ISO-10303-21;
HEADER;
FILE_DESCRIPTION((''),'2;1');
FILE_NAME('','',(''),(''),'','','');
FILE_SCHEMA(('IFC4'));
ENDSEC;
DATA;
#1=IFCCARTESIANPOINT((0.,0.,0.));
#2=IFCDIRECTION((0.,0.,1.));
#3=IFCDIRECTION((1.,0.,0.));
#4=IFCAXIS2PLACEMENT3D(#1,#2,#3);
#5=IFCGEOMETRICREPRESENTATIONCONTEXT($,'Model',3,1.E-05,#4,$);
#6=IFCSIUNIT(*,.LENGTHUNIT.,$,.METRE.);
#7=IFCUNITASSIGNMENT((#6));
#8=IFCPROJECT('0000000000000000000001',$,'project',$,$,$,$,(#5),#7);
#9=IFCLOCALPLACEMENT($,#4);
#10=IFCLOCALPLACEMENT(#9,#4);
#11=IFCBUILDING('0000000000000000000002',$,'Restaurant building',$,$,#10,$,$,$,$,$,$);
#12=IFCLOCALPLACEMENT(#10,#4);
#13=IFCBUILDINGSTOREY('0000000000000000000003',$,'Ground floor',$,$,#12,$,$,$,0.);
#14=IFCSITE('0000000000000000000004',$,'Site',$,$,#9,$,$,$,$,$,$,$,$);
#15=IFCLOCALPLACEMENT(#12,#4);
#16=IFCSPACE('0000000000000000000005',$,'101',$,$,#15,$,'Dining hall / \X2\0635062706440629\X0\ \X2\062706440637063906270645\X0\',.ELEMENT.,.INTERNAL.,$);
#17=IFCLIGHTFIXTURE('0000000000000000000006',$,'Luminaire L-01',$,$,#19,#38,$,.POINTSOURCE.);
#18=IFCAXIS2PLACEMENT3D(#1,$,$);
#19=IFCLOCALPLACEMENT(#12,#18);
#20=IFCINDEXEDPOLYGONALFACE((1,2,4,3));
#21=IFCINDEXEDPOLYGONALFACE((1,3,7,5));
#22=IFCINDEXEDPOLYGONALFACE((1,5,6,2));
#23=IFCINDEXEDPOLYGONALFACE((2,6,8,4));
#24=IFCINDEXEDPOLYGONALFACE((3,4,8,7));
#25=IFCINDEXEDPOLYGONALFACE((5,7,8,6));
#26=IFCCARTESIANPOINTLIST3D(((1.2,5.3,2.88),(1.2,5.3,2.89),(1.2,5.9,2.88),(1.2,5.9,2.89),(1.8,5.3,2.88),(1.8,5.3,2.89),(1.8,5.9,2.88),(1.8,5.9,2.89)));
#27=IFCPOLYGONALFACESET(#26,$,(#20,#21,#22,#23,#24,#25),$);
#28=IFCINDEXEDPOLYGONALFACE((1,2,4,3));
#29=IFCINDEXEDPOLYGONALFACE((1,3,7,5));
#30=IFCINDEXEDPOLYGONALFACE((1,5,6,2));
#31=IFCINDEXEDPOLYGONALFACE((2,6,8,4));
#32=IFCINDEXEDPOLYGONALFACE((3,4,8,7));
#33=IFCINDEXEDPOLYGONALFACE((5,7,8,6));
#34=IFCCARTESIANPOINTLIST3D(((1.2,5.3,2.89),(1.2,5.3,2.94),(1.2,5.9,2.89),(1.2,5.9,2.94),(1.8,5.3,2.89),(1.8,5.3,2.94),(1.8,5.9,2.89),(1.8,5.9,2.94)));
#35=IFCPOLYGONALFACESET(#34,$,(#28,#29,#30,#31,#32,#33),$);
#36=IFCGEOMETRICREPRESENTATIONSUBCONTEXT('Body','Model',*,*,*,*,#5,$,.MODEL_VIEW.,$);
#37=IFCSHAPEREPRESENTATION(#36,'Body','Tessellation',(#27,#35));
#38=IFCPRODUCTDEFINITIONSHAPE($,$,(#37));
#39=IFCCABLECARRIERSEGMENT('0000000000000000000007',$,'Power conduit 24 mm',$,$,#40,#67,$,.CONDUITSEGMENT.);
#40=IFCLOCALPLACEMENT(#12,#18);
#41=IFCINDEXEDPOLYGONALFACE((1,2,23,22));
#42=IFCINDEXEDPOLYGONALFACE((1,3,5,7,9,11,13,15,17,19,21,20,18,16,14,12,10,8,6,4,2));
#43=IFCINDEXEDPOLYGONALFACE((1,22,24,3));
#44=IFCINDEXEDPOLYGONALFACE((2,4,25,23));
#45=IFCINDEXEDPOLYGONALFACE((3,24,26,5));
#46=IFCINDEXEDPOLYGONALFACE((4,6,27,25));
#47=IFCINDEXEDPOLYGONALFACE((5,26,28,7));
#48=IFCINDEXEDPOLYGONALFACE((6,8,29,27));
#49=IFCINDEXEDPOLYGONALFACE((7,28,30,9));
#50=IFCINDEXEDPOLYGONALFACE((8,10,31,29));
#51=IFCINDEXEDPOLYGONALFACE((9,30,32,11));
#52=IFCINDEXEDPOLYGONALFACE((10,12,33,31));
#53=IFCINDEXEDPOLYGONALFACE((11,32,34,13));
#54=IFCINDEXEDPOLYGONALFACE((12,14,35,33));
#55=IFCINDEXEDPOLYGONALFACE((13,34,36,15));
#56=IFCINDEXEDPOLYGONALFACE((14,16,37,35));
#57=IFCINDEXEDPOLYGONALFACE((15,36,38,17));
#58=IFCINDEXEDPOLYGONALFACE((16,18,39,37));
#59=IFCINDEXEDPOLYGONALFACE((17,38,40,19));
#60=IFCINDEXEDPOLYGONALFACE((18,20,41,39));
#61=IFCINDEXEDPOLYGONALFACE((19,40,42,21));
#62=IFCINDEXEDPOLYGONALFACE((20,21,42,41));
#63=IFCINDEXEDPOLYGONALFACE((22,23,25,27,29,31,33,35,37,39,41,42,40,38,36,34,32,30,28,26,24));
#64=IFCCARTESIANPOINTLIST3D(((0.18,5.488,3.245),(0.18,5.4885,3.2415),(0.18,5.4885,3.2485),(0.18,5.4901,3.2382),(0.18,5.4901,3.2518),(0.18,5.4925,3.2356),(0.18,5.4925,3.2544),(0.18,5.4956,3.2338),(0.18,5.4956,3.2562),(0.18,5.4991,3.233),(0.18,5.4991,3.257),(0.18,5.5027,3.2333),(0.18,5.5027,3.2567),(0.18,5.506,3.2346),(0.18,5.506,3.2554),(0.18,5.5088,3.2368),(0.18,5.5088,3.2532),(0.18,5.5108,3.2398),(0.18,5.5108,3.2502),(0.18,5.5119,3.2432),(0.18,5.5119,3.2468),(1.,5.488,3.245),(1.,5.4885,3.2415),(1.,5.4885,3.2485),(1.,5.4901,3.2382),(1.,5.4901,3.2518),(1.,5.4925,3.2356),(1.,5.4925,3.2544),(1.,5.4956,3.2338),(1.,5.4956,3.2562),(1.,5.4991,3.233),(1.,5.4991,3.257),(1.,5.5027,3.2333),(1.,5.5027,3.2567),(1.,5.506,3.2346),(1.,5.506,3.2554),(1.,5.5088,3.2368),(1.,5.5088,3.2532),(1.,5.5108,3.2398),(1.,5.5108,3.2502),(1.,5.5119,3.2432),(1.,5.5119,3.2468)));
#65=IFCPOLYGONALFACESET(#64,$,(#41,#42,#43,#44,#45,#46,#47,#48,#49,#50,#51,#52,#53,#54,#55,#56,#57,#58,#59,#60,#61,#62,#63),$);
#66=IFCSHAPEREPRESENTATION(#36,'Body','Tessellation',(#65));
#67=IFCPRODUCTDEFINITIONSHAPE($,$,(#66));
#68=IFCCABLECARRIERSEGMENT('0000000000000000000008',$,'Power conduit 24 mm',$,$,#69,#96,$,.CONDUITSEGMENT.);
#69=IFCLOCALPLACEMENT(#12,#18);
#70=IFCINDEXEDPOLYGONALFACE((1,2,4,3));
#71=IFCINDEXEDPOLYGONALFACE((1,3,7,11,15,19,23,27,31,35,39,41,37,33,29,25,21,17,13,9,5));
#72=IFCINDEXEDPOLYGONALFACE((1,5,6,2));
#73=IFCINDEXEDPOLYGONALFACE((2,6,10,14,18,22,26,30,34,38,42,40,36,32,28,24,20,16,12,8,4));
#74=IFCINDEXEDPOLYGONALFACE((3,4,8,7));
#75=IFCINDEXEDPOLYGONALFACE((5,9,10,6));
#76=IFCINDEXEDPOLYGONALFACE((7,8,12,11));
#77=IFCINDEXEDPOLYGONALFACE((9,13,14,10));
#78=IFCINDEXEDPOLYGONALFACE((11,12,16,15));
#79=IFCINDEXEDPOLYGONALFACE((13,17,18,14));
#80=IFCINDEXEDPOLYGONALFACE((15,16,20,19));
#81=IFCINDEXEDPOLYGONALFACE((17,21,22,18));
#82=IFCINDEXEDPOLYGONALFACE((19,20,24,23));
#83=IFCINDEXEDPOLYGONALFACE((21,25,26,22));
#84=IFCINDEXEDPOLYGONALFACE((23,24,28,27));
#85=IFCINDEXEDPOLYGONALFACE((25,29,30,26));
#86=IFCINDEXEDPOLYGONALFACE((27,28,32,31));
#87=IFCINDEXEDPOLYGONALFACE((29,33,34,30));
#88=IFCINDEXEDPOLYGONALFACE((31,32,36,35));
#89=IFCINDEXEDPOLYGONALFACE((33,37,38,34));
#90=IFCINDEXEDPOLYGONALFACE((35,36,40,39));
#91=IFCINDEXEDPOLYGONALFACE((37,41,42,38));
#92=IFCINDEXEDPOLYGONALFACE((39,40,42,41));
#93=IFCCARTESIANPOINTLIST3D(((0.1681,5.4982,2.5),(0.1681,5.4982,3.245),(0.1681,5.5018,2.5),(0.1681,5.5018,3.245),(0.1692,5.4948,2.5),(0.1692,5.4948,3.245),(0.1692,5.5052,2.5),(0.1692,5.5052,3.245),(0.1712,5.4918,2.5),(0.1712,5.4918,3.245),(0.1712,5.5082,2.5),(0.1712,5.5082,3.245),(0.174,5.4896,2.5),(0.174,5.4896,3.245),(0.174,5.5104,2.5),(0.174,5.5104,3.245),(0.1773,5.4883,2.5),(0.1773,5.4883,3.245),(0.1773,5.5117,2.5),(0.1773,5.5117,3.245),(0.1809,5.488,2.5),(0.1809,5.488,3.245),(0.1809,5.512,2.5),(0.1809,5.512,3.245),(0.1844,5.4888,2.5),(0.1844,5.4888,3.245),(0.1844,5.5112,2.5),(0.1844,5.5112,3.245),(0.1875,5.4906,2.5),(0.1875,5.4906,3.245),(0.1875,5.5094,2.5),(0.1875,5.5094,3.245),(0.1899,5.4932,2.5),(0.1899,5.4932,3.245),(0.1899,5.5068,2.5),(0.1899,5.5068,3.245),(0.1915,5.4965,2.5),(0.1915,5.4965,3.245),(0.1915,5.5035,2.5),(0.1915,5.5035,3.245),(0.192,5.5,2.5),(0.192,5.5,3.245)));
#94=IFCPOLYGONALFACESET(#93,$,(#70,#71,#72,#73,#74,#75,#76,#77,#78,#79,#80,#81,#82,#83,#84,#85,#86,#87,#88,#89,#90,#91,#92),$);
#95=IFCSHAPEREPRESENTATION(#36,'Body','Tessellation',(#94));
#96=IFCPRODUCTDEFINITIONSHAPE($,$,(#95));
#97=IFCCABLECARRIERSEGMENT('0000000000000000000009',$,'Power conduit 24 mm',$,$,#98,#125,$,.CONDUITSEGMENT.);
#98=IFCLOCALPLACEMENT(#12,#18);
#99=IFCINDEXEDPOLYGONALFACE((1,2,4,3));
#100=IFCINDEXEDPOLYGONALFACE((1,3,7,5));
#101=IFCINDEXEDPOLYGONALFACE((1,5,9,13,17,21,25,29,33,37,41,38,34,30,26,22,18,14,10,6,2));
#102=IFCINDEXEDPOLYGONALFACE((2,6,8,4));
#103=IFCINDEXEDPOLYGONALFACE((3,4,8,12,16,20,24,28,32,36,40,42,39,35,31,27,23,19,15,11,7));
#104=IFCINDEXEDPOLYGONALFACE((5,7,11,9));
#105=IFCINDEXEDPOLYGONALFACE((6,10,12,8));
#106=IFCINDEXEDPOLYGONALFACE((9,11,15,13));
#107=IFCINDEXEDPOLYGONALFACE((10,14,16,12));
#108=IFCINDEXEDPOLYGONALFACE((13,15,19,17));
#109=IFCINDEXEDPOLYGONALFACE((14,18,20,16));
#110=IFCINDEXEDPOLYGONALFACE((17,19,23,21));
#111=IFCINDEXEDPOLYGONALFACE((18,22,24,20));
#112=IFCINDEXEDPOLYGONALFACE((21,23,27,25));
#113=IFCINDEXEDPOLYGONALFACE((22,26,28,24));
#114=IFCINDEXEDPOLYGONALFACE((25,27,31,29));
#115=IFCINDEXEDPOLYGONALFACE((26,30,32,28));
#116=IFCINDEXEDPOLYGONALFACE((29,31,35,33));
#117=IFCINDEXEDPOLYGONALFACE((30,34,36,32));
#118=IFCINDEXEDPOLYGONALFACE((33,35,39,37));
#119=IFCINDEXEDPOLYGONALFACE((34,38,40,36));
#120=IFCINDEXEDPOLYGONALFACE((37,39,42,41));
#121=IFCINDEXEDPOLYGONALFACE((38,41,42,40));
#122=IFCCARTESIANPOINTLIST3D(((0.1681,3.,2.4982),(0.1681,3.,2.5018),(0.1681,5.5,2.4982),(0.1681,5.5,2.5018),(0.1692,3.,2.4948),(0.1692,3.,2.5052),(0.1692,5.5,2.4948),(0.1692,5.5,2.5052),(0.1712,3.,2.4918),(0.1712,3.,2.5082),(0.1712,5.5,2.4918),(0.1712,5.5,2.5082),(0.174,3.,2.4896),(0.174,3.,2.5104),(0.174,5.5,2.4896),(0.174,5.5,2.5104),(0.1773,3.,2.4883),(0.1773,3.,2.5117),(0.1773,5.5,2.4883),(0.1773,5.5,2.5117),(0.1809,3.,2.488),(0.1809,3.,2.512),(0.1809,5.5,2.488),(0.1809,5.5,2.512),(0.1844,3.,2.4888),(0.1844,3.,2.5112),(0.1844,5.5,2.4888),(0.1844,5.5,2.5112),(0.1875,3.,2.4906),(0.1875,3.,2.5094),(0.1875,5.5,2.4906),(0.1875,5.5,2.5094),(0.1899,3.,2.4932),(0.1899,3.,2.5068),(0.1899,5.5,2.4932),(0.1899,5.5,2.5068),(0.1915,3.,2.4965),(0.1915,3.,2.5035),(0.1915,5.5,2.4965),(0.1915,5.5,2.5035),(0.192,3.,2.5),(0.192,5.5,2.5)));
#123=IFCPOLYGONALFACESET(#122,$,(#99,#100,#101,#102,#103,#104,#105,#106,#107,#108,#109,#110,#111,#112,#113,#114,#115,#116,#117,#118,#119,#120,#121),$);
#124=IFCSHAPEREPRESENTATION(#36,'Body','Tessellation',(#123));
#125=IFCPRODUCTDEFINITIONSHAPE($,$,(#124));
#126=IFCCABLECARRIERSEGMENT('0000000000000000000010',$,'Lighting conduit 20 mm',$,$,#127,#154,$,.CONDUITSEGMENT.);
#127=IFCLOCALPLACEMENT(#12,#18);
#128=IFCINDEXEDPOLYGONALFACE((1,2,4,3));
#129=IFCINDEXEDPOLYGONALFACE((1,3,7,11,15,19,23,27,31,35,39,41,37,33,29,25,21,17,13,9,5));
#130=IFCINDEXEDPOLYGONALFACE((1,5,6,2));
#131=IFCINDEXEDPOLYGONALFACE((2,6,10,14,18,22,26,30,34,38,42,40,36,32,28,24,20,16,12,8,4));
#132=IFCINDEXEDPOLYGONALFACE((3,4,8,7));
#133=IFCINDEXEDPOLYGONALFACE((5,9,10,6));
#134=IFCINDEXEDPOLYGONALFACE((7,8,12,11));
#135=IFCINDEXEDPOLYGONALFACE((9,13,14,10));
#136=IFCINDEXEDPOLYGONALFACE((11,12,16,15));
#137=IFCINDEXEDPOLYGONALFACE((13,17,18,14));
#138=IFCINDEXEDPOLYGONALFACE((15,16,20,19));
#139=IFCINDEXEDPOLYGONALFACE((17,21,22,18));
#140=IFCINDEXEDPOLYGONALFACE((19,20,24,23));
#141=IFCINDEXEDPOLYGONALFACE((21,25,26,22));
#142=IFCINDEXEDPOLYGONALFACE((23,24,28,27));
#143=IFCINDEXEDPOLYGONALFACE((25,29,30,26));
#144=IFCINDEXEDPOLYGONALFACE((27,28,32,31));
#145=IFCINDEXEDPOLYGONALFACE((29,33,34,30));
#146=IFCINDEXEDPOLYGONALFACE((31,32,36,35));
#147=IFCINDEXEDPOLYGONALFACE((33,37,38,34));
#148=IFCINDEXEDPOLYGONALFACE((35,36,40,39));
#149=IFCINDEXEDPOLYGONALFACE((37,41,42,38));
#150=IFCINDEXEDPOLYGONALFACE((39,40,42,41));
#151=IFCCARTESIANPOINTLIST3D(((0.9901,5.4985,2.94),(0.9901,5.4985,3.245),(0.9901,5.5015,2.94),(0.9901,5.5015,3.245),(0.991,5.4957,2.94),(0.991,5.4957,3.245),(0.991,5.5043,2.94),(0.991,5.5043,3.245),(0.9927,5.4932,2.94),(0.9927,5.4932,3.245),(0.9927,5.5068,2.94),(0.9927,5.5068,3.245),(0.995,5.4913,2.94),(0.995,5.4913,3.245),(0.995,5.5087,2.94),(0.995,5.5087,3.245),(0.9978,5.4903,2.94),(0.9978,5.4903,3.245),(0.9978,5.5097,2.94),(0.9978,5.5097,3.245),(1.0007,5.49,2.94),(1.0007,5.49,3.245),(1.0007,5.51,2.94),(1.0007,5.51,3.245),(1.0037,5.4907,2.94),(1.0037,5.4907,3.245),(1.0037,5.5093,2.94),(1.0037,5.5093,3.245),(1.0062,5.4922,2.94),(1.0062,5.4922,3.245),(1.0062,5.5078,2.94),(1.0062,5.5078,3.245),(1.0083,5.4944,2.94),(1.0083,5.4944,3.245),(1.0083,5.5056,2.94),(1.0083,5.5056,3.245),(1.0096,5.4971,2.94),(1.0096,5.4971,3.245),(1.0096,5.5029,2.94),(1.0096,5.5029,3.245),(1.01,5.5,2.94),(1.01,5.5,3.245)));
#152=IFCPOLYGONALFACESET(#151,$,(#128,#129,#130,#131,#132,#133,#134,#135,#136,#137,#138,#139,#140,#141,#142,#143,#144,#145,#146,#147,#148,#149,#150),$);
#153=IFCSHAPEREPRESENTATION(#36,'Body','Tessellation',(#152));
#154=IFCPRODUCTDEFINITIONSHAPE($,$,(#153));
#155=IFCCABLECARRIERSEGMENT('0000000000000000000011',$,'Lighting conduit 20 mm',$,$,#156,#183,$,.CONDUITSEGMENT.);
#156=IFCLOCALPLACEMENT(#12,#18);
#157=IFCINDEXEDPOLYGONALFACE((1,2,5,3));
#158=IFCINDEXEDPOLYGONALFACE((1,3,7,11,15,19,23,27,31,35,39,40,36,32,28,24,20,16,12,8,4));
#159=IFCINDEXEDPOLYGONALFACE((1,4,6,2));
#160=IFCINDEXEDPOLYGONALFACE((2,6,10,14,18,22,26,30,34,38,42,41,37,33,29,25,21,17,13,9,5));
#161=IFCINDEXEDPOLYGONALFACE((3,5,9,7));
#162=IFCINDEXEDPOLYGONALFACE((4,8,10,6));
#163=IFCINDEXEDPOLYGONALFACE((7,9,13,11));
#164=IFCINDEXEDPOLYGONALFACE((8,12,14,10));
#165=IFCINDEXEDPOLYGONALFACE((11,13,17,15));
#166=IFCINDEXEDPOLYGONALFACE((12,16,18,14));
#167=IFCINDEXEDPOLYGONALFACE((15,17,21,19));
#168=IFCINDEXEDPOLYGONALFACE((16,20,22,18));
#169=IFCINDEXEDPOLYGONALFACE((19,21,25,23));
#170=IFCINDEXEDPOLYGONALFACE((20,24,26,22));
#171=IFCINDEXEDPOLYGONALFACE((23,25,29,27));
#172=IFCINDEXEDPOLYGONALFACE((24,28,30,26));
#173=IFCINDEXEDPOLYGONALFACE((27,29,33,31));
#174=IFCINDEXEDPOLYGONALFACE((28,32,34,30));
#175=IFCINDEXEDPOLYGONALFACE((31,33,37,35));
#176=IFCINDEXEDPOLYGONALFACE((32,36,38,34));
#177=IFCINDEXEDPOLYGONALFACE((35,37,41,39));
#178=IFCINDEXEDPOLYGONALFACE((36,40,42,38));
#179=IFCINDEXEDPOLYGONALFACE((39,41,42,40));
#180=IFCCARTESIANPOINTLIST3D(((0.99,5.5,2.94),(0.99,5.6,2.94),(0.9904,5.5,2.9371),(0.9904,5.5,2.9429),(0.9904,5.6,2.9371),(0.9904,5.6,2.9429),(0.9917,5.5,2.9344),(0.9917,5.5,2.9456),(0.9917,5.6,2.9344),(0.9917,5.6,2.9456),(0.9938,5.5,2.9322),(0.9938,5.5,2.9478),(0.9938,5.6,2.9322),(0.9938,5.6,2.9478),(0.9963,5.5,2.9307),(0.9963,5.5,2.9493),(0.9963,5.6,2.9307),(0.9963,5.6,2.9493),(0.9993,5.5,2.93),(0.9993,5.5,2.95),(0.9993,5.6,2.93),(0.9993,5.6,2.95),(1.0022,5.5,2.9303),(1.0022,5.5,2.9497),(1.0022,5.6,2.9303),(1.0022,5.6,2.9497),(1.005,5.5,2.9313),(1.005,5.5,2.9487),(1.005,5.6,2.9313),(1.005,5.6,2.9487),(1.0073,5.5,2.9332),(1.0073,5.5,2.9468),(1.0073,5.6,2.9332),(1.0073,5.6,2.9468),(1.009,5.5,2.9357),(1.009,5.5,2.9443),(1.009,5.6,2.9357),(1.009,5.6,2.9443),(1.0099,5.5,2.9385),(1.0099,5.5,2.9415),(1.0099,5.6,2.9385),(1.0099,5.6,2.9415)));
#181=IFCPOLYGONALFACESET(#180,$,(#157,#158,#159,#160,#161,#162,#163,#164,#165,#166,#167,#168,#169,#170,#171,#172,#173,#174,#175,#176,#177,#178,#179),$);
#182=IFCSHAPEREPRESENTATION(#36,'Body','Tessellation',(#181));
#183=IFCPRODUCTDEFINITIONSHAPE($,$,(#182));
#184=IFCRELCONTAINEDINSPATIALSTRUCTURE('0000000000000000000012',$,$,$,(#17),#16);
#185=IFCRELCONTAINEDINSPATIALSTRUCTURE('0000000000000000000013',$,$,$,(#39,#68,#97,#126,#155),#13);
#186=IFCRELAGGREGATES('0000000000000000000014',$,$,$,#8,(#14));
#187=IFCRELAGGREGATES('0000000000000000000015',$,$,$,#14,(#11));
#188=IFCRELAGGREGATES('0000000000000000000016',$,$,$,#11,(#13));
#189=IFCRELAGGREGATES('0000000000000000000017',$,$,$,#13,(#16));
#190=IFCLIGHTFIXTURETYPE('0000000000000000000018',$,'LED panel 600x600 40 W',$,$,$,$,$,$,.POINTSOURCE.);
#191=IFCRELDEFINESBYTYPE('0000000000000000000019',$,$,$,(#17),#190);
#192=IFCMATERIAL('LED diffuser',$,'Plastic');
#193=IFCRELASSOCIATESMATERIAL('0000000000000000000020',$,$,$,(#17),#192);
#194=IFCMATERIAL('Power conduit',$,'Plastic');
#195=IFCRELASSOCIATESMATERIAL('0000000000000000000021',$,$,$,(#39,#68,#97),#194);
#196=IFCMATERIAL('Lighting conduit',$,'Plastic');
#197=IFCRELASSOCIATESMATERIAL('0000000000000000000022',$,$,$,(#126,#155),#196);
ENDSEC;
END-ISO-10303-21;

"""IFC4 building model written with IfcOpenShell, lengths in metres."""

from ifc_helpers import new_model, si_unit, frame, origin, origin_with_axes, origin_2d, place, context, subcontext, project, spatial, rectangle, circle, extrude, source, transform, mapped, material, type_object, type_shapes, element, save


model = new_model("IFC4")

# Units and contexts
model_context = context("Model", 3, precision=1e-05, world=origin_with_axes())
body_context = subcontext(model_context, "Body", "Model", "MODEL_VIEW")
ifc_project = project(units=[si_unit("LENGTHUNIT", "METRE")], contexts=[model_context])

# Site, building, storey, space
site_placement = place(None, origin_with_axes())
site = spatial("IfcSite", under=ifc_project, at=site_placement, Name="Site")
building_placement = place(site_placement, origin_with_axes())
building = spatial("IfcBuilding", under=site, at=building_placement, Name="Restaurant building")
storey_placement = place(building_placement, origin_with_axes())
storey = spatial("IfcBuildingStorey", under=building, at=storey_placement, Name="Ground floor", Elevation=0.0)
space_placement = place(storey_placement, origin_with_axes())
space = spatial("IfcSpace", under=storey, at=space_placement, Name="101", LongName="Dining hall / صالة الطعام", CompositionType="ELEMENT", PredefinedType="INTERNAL")

# Light fixture
ifc_material_1 = material(Name="LED diffuser", Category="Plastic")
light_fixture_type = type_object("IfcLightFixtureType", Name="LED panel 600x600 40 W", PredefinedType="POINTSOURCE")
shared_shape_1 = source(origin(), body_context, "Body", "SweptSolid", [
    extrude(rectangle(XDim=0.6, YDim=0.6, at=origin_2d()), frame((0.0, 0.0, -0.06)), (0.0, 0.0, 1.0), 0.01),
    extrude(rectangle(XDim=0.6, YDim=0.6, at=origin_2d()), frame((0.0, 0.0, -0.05)), (0.0, 0.0, 1.0), 0.05),
])
type_shapes(light_fixture_type, [shared_shape_1])
light_fixture_placement = place(storey_placement, frame((1.5, 5.6, 2.94)))
element("IfcLightFixture", 1, at=light_fixture_placement, inside=space, type_object=light_fixture_type, material=ifc_material_1, Name="Luminaire L-01", PredefinedType="POINTSOURCE", context=body_context, shape_type="MappedRepresentation", body=[
    mapped(shared_shape_1, transform((0.0, 0.0, 0.0))),
])

# Cable carrier segments
ifc_material_2 = material(Name="Power conduit", Category="Plastic")
cable_carrier_segment_1_placement = place(storey_placement, frame((1.0, 5.5, 3.245)))
element("IfcCableCarrierSegment", 2, at=cable_carrier_segment_1_placement, inside=storey, material=ifc_material_2, Name="Power conduit 24 mm", PredefinedType="CONDUITSEGMENT", context=body_context, shape_type="SweptSolid", body=[
    extrude(circle(Radius=0.012, at=origin_2d()), frame((0.0, 0.0, 0.0), z_axis=(-1.0, 0.0, 0.0), x_axis=(0.0, -1.0, 0.0)), (0.0, 0.0, 1.0), 0.82),
])
cable_carrier_segment_2_placement = place(storey_placement, frame((0.18, 5.5, 3.245)))
element("IfcCableCarrierSegment", 3, at=cable_carrier_segment_2_placement, inside=storey, material=ifc_material_2, Name="Power conduit 24 mm", PredefinedType="CONDUITSEGMENT", context=body_context, shape_type="SweptSolid", body=[
    extrude(circle(Radius=0.012, at=origin_2d()), frame((0.0, 0.0, 0.0), z_axis=(0.0, 0.0, -1.0), x_axis=(1.0, 0.0, 0.0)), (0.0, 0.0, 1.0), 0.745),
])
cable_carrier_segment_3_placement = place(storey_placement, frame((0.18, 5.5, 2.5)))
element("IfcCableCarrierSegment", 4, at=cable_carrier_segment_3_placement, inside=storey, material=ifc_material_2, Name="Power conduit 24 mm", PredefinedType="CONDUITSEGMENT", context=body_context, shape_type="SweptSolid", body=[
    extrude(circle(Radius=0.012, at=origin_2d()), frame((0.0, 0.0, 0.0), z_axis=(0.0, -1.0, 0.0), x_axis=(1.0, 0.0, 0.0)), (0.0, 0.0, 1.0), 2.5),
])
ifc_material_3 = material(Name="Lighting conduit", Category="Plastic")
cable_carrier_segment_4_placement = place(storey_placement, frame((1.0, 5.5, 3.245)))
element("IfcCableCarrierSegment", 5, at=cable_carrier_segment_4_placement, inside=storey, material=ifc_material_3, Name="Lighting conduit 20 mm", PredefinedType="CONDUITSEGMENT", context=body_context, shape_type="SweptSolid", body=[
    extrude(circle(Radius=0.01, at=origin_2d()), frame((0.0, 0.0, 0.0), z_axis=(0.0, 0.0, -1.0), x_axis=(1.0, 0.0, 0.0)), (0.0, 0.0, 1.0), 0.305),
])
cable_carrier_segment_5_placement = place(storey_placement, frame((1.0, 5.5, 2.94)))
element("IfcCableCarrierSegment", 6, at=cable_carrier_segment_5_placement, inside=storey, material=ifc_material_3, Name="Lighting conduit 20 mm", PredefinedType="CONDUITSEGMENT", context=body_context, shape_type="SweptSolid", body=[
    extrude(circle(Radius=0.01, at=origin_2d()), frame((0.0, 0.0, 0.0), z_axis=(0.0, 1.0, 0.0), x_axis=(-1.0, 0.0, 0.0)), (0.0, 0.0, 1.0), 0.1),
])

save(model, "model.ifc")
